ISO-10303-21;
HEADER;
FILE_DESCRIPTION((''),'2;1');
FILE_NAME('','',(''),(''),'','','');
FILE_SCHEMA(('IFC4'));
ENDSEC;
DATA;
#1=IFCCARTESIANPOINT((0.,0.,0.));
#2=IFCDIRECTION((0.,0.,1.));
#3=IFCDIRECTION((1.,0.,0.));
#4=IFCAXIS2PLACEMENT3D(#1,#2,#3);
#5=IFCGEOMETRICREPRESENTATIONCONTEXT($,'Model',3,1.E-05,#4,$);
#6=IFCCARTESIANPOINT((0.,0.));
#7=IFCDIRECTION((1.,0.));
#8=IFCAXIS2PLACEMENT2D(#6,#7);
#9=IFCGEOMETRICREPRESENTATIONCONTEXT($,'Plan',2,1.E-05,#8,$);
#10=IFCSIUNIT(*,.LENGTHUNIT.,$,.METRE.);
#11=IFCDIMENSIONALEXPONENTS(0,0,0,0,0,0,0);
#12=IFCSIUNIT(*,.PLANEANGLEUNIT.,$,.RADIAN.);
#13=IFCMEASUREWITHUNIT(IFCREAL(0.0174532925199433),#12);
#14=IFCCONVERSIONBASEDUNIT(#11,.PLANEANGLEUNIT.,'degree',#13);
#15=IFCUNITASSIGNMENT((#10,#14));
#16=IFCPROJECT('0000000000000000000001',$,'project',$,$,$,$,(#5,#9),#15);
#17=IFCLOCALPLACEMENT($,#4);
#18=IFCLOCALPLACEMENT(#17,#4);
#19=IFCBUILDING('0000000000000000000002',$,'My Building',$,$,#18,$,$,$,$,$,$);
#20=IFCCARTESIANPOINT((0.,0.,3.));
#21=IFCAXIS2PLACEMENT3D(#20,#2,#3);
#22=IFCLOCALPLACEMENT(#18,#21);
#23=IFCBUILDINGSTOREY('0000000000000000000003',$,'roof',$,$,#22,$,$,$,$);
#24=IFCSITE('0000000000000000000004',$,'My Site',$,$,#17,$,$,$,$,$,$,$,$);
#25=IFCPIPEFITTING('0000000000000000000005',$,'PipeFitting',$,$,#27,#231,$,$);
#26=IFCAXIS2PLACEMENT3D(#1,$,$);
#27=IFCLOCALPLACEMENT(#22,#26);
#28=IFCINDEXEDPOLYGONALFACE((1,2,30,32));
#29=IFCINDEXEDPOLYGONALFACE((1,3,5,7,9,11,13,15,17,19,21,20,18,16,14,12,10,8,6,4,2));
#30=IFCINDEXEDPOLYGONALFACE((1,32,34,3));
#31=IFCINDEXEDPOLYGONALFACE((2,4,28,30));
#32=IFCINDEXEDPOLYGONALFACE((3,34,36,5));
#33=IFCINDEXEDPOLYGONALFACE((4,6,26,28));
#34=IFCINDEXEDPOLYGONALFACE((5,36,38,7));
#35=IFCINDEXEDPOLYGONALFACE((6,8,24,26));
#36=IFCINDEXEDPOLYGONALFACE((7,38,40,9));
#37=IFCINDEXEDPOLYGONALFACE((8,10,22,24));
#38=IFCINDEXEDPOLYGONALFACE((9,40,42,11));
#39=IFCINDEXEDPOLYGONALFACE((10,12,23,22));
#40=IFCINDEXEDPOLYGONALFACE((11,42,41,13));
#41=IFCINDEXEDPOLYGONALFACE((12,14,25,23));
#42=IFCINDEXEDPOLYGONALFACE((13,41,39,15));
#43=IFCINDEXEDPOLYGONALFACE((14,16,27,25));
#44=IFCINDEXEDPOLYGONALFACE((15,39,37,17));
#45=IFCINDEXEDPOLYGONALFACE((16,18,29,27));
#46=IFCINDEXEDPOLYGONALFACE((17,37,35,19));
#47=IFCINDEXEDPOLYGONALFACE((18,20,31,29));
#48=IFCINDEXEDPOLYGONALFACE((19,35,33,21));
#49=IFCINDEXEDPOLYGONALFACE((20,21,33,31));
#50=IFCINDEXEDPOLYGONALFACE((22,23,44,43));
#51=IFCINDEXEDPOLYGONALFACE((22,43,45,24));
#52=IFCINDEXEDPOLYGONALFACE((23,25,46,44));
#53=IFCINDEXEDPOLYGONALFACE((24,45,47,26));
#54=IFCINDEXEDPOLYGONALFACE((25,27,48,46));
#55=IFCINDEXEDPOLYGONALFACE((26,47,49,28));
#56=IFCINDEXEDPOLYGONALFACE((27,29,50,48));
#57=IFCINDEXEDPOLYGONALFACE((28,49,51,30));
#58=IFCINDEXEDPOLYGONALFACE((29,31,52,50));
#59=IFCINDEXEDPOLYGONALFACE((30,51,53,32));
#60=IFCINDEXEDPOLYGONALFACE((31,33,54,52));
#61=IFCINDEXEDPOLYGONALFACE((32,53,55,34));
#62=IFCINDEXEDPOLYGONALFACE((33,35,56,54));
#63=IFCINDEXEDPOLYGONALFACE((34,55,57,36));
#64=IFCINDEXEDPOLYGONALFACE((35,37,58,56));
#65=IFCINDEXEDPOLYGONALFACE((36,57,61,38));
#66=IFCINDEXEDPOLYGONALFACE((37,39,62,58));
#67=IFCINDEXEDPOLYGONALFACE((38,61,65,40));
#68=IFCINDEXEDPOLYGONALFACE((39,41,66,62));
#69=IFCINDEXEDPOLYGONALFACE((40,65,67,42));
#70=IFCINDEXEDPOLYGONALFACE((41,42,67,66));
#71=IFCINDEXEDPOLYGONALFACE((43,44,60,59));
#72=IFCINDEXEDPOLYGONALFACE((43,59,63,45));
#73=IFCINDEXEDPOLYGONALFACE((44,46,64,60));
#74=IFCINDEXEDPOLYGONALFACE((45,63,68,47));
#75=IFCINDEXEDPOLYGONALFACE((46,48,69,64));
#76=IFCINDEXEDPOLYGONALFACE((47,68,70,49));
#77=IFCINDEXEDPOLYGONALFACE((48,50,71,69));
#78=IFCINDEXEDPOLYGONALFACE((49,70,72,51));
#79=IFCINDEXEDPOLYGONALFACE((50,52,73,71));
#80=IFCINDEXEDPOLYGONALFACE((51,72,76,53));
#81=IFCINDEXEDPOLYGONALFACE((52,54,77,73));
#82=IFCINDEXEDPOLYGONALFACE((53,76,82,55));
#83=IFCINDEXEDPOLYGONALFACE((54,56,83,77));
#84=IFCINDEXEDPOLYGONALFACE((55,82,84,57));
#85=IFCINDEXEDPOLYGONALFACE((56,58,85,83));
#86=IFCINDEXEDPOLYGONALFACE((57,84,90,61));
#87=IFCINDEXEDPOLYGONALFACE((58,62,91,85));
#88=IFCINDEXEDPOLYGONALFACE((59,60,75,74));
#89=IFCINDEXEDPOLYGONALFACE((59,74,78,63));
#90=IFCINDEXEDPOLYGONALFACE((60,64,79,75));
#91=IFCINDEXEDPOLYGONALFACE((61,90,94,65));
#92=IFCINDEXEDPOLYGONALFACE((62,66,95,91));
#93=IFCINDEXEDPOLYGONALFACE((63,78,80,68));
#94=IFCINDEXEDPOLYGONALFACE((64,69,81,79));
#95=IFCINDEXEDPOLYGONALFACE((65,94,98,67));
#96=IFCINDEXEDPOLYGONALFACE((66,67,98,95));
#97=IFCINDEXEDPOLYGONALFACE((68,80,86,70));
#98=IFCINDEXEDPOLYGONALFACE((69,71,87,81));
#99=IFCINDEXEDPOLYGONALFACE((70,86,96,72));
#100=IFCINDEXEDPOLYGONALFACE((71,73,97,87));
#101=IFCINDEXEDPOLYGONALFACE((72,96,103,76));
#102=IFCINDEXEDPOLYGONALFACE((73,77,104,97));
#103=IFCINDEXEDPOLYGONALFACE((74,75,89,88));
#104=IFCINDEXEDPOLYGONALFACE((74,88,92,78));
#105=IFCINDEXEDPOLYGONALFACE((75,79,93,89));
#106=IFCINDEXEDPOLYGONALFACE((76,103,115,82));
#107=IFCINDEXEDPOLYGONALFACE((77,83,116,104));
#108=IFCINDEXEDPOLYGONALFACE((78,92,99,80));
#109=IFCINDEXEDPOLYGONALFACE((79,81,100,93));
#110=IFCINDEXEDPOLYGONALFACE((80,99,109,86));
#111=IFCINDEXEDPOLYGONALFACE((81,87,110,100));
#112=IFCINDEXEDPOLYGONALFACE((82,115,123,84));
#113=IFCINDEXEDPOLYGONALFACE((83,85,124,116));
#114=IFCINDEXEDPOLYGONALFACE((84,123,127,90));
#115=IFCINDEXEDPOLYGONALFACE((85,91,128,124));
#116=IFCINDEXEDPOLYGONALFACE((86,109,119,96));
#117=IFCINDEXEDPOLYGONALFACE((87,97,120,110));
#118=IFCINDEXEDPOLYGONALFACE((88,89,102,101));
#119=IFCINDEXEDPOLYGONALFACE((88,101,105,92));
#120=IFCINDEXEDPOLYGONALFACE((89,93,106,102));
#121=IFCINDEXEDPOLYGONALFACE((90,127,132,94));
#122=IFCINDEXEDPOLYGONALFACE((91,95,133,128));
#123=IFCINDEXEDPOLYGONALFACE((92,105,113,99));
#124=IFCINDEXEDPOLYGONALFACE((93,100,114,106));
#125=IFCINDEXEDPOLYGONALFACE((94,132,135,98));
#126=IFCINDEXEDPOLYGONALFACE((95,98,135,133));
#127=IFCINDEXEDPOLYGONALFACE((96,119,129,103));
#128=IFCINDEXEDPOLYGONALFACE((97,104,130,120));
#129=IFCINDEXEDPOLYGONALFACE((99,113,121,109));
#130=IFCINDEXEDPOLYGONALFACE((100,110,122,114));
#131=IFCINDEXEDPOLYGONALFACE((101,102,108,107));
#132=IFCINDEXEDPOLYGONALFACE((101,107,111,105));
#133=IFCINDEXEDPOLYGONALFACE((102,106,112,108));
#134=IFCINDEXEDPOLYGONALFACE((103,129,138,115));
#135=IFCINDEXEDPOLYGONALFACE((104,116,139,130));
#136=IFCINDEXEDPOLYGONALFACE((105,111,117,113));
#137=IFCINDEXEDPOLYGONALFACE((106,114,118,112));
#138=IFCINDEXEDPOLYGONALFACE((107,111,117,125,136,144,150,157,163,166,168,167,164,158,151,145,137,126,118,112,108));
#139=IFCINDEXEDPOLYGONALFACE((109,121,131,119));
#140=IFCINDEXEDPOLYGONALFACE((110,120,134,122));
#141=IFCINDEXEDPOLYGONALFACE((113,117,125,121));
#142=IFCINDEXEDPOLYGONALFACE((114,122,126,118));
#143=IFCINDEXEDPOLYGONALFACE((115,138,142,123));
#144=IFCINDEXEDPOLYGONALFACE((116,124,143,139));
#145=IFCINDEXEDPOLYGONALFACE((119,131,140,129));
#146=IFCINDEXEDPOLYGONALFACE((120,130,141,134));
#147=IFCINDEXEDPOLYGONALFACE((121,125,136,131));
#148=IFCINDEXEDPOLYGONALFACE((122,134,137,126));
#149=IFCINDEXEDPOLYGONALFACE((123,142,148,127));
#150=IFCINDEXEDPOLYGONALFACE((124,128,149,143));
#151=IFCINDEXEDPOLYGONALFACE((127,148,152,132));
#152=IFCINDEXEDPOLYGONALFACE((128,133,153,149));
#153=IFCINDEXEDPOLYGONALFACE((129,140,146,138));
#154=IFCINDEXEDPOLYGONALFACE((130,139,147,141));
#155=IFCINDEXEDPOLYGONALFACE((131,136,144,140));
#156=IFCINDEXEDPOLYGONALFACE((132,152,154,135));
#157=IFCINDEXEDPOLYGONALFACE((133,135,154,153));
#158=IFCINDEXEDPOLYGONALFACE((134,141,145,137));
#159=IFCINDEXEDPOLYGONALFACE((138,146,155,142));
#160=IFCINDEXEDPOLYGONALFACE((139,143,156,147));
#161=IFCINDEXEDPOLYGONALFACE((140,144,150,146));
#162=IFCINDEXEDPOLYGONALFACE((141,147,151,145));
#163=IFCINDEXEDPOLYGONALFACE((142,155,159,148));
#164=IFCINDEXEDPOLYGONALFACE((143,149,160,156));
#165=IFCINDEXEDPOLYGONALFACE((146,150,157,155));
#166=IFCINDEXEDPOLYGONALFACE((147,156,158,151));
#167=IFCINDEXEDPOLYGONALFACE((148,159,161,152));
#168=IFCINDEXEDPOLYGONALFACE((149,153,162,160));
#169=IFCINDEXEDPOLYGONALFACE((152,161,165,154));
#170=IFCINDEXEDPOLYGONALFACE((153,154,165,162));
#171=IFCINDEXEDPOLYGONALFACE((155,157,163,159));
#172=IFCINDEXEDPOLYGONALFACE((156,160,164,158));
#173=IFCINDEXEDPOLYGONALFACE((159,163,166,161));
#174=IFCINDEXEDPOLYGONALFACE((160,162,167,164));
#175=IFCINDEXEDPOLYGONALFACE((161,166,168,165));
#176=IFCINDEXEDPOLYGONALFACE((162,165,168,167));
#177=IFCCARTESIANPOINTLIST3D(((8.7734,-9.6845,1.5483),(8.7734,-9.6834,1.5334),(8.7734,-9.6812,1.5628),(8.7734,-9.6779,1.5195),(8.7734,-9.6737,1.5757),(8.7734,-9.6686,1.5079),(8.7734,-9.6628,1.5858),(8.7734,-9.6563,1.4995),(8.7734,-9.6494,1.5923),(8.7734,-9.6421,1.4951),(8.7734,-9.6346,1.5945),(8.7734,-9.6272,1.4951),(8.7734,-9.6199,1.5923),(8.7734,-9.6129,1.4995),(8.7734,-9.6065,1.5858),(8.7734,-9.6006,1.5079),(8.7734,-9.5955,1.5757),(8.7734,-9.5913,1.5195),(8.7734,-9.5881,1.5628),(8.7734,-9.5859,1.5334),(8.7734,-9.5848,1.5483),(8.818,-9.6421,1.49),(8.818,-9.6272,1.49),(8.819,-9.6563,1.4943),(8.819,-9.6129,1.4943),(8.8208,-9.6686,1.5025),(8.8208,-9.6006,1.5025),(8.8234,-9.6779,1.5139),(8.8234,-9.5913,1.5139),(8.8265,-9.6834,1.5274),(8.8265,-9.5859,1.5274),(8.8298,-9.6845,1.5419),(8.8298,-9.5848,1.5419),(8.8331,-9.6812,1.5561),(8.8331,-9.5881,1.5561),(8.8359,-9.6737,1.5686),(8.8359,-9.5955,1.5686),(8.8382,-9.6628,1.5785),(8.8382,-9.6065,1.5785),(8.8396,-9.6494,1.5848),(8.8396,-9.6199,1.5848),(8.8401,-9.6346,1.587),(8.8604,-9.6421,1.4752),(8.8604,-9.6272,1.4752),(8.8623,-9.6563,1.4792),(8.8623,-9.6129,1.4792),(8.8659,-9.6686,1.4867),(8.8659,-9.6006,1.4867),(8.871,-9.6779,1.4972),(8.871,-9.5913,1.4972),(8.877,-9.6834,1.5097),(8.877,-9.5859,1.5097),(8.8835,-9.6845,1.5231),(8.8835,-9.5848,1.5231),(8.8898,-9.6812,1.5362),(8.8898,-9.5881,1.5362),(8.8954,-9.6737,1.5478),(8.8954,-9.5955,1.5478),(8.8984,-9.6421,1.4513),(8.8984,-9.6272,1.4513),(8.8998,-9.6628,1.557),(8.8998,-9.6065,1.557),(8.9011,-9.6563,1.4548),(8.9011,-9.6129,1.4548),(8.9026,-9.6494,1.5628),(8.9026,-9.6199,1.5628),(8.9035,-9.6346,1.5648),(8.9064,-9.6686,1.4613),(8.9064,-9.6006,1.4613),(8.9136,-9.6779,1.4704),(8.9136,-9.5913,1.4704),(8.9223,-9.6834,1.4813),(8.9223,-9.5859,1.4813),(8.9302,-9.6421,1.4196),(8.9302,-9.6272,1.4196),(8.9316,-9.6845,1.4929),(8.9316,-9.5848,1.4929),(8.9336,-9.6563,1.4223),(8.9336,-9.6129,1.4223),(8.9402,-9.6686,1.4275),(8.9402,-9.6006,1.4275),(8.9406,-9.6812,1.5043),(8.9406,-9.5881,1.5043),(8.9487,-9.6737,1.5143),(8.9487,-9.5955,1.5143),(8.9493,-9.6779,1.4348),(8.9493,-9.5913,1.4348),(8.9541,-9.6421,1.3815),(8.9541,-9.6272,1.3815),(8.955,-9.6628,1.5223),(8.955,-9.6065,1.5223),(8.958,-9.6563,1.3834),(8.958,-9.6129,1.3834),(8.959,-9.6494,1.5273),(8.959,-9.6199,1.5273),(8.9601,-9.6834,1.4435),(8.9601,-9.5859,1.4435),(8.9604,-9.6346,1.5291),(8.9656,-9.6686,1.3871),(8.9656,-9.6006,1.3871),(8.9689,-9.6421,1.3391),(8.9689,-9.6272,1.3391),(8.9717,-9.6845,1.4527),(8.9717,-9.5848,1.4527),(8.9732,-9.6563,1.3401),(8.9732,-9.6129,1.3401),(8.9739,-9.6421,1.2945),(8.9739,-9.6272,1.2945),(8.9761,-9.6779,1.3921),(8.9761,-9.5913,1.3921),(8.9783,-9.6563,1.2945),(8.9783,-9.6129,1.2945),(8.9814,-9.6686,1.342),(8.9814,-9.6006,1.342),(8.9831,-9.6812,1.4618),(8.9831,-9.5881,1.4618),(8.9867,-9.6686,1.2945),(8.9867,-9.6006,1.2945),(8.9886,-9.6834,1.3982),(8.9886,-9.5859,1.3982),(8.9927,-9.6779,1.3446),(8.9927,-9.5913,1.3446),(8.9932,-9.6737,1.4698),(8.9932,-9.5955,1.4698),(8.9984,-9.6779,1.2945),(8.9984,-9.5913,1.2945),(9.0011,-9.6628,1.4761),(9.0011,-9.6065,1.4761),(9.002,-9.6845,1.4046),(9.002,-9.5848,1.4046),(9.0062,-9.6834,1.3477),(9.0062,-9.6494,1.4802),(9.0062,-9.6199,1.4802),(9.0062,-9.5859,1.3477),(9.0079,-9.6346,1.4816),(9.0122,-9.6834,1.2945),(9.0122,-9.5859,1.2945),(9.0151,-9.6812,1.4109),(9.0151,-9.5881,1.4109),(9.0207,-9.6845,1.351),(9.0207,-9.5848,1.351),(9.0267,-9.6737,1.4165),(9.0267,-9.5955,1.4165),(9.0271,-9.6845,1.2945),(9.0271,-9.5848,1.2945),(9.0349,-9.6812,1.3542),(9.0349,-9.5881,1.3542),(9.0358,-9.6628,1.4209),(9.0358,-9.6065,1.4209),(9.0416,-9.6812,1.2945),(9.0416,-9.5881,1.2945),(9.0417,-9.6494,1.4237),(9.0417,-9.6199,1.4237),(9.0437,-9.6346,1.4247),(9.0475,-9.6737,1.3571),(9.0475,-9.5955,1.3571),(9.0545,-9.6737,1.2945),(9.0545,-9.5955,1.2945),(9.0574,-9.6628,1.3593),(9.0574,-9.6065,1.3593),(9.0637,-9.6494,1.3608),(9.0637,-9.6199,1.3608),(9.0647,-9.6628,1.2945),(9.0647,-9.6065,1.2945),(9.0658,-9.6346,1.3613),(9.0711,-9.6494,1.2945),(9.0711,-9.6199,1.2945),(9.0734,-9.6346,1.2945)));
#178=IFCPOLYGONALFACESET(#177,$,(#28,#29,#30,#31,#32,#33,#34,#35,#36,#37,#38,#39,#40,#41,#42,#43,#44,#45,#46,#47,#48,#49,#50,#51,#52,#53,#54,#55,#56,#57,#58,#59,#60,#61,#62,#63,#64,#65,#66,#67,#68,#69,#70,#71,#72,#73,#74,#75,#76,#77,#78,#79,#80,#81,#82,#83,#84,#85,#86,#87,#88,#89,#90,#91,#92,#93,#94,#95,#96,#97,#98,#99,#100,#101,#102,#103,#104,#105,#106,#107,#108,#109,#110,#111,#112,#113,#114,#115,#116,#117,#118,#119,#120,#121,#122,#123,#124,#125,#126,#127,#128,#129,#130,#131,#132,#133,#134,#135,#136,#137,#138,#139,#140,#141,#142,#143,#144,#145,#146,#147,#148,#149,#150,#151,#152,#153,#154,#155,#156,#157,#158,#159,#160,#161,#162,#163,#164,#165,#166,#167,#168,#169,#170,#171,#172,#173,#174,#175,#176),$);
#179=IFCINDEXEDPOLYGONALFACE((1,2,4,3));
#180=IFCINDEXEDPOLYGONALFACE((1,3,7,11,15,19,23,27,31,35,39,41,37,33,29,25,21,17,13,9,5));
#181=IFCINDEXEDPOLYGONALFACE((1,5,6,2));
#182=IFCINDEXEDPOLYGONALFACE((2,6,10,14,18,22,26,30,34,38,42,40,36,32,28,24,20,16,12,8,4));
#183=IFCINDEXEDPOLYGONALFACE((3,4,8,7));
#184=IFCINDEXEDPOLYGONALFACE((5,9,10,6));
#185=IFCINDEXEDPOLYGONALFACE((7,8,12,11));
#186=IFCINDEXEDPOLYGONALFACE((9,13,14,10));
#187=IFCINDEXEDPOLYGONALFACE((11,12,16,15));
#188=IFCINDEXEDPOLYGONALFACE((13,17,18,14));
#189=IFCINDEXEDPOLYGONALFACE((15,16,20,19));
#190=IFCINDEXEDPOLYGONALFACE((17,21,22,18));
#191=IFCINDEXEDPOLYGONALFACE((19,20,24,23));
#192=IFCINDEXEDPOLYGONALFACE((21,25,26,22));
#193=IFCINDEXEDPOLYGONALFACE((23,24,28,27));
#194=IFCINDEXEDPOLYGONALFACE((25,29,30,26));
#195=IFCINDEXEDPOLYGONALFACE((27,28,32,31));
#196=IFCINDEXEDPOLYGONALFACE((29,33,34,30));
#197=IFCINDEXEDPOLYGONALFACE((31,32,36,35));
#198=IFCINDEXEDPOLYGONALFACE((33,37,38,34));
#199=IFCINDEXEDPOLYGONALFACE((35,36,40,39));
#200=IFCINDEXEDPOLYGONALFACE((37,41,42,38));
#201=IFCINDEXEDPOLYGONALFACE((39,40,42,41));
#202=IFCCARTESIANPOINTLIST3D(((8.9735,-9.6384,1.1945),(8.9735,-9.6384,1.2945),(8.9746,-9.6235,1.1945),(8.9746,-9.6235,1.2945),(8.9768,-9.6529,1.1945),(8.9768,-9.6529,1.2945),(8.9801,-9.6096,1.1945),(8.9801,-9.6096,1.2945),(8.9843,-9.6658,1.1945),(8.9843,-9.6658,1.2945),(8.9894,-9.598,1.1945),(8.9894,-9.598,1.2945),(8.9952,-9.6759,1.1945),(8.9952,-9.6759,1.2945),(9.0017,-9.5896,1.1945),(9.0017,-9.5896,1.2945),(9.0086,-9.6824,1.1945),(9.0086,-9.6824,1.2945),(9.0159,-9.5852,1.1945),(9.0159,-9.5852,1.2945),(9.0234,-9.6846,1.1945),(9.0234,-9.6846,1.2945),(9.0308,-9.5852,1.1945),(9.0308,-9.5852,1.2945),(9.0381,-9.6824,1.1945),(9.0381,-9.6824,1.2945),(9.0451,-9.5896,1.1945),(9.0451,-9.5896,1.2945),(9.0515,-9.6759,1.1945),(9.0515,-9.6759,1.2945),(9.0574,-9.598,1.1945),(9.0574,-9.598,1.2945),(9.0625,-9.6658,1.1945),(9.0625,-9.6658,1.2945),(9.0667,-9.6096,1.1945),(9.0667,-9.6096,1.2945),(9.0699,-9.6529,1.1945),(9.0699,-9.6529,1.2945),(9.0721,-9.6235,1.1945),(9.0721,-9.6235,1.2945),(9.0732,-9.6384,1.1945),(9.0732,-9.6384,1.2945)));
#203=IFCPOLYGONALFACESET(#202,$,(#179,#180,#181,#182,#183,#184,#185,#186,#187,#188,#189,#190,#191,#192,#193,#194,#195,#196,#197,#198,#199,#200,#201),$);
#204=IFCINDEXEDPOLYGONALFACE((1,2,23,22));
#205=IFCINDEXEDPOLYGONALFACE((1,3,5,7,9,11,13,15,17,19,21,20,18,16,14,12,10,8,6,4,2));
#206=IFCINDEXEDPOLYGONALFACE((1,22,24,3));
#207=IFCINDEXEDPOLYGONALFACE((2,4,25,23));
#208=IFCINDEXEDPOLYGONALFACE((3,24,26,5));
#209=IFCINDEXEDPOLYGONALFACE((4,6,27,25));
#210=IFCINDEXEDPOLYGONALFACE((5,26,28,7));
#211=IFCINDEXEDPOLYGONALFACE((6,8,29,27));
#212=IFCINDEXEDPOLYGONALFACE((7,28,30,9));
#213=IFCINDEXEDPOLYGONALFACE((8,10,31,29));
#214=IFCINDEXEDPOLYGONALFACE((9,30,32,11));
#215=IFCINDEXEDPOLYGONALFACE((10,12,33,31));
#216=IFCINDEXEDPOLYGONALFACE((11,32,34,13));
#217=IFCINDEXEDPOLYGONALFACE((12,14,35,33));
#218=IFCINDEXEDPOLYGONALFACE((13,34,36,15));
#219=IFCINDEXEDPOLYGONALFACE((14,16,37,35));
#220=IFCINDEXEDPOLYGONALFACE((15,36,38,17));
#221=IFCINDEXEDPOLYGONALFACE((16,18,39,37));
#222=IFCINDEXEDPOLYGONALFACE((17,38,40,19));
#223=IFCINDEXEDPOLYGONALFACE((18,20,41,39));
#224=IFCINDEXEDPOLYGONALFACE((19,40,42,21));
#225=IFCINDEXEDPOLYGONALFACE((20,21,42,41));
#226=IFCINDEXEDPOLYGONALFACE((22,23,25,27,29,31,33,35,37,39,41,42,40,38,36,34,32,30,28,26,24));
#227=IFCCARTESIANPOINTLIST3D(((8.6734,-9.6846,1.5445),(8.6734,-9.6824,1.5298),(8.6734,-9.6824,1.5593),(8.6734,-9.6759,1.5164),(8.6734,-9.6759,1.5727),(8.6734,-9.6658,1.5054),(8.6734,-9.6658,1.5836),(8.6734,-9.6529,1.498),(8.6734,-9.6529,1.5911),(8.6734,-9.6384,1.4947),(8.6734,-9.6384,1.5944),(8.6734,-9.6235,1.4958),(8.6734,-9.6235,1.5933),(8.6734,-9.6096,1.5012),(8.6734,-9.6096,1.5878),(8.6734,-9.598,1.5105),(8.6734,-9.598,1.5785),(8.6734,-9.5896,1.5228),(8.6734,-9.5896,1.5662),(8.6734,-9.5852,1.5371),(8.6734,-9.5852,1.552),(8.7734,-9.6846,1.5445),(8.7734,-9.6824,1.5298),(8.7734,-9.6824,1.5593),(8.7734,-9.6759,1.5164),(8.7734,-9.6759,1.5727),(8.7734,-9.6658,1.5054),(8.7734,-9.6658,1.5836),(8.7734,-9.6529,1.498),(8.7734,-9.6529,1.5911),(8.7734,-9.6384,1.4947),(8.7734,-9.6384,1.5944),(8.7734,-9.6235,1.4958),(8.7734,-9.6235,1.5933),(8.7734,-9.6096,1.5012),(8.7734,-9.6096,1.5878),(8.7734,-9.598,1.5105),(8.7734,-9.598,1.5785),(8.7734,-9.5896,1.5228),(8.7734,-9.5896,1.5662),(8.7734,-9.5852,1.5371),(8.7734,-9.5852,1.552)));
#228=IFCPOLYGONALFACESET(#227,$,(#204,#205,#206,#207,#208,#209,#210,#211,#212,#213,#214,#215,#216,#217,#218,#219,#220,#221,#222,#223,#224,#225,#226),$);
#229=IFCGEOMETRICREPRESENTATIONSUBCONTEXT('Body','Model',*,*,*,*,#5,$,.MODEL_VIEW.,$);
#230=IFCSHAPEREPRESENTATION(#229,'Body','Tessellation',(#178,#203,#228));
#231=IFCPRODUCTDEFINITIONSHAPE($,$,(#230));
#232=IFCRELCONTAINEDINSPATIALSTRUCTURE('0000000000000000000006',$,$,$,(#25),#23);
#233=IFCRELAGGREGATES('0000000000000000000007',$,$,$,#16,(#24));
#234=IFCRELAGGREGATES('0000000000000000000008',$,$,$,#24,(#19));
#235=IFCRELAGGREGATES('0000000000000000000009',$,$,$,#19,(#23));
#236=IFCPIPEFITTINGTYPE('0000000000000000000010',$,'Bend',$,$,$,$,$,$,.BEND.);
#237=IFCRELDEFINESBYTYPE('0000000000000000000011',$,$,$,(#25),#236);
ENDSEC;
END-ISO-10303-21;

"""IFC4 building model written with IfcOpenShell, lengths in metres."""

from ifc_helpers import new_model, entity, si_unit, converted_unit, frame, origin_with_axes, origin_2d_with_axis, place, context, subcontext, project, spatial, circle, extrude, source, transform, mapped, type_object, type_shapes, element, save


model = new_model("IFC4")

# Units and contexts
model_context = context("Model", 3, precision=1e-05, world=origin_with_axes())
plan_context = context("Plan", 2, precision=1e-05, world=origin_2d_with_axis())
body_context_1 = subcontext(model_context, "Body", "Model", "MODEL_VIEW")
ifc_project = project(units=[si_unit("LENGTHUNIT", "METRE"), converted_unit("PLANEANGLEUNIT", "degree", entity("IfcReal", 0.0174532925199433), si_unit("PLANEANGLEUNIT", "RADIAN"), dimensions=[0, 0, 0, 0, 0, 0, 0])], contexts=[model_context, plan_context])

# Site, building, storey
site_placement = place(None, origin_with_axes())
site = spatial("IfcSite", under=ifc_project, at=site_placement, Name="My Site")
building_placement = place(site_placement, origin_with_axes())
building = spatial("IfcBuilding", under=site, at=building_placement, Name="My Building")
storey_placement = place(building_placement, frame((0.0, 0.0, 3.0), z_axis=(0.0, 0.0, 1.0), x_axis=(1.0, 0.0, 0.0)))
storey = spatial("IfcBuildingStorey", under=building, at=storey_placement, Name="roof")

# Pipe fitting
pipe_fitting_type_1 = type_object("IfcPipeFittingType", Name="Bend", PredefinedType="BEND")
shared_shape_1 = source(origin_with_axes(), body_context_1, "Body", "SolidModel", [
    entity("IfcSweptDiskSolid", entity("IfcIndexedPolyCurve", entity("IfcCartesianPointList3D", [[0.0, 0.0, 0.1], [0.0, -0.0732, 0.2768], [0.0, -0.25, 0.35]]), [entity("IfcArcIndex", [1, 2, 3])]), 0.05),
    extrude(circle(Radius=0.05), origin_with_axes(), (0.0, 0.0, 1.0), 0.1),
    extrude(circle(Radius=0.05), frame((0.0, -0.25, 0.35), z_axis=(0.0, -1.0, 0.0), x_axis=(1.0, 0.0, 0.0)), (0.0, 0.0, 1.0), 0.1),
])
type_shapes(pipe_fitting_type_1, [shared_shape_1])
for number, where, z_axis, x_axis, name in (
    (1, (9.0234, -9.6346, 1.1945), (0.000001, -0.000001, 1.0), (0.0, -1.0, -0.000001), "PipeFitting"),
):
    element("IfcPipeFitting", number, at=place(storey_placement, frame(where, z_axis=z_axis, x_axis=x_axis)), inside=storey, type_object=pipe_fitting_type_1, Name=name, context=body_context_1, shape_type="MappedRepresentation", body=[
        mapped(shared_shape_1, transform((0.0, 0.0, 0.0), x_axis=(1.0, 0.0, 0.0), y_axis=(0.0, 1.0, 0.0), z_axis=(0.0, 0.0, 1.0), scale=1.0)),
    ])

save(model, "model.ifc")
